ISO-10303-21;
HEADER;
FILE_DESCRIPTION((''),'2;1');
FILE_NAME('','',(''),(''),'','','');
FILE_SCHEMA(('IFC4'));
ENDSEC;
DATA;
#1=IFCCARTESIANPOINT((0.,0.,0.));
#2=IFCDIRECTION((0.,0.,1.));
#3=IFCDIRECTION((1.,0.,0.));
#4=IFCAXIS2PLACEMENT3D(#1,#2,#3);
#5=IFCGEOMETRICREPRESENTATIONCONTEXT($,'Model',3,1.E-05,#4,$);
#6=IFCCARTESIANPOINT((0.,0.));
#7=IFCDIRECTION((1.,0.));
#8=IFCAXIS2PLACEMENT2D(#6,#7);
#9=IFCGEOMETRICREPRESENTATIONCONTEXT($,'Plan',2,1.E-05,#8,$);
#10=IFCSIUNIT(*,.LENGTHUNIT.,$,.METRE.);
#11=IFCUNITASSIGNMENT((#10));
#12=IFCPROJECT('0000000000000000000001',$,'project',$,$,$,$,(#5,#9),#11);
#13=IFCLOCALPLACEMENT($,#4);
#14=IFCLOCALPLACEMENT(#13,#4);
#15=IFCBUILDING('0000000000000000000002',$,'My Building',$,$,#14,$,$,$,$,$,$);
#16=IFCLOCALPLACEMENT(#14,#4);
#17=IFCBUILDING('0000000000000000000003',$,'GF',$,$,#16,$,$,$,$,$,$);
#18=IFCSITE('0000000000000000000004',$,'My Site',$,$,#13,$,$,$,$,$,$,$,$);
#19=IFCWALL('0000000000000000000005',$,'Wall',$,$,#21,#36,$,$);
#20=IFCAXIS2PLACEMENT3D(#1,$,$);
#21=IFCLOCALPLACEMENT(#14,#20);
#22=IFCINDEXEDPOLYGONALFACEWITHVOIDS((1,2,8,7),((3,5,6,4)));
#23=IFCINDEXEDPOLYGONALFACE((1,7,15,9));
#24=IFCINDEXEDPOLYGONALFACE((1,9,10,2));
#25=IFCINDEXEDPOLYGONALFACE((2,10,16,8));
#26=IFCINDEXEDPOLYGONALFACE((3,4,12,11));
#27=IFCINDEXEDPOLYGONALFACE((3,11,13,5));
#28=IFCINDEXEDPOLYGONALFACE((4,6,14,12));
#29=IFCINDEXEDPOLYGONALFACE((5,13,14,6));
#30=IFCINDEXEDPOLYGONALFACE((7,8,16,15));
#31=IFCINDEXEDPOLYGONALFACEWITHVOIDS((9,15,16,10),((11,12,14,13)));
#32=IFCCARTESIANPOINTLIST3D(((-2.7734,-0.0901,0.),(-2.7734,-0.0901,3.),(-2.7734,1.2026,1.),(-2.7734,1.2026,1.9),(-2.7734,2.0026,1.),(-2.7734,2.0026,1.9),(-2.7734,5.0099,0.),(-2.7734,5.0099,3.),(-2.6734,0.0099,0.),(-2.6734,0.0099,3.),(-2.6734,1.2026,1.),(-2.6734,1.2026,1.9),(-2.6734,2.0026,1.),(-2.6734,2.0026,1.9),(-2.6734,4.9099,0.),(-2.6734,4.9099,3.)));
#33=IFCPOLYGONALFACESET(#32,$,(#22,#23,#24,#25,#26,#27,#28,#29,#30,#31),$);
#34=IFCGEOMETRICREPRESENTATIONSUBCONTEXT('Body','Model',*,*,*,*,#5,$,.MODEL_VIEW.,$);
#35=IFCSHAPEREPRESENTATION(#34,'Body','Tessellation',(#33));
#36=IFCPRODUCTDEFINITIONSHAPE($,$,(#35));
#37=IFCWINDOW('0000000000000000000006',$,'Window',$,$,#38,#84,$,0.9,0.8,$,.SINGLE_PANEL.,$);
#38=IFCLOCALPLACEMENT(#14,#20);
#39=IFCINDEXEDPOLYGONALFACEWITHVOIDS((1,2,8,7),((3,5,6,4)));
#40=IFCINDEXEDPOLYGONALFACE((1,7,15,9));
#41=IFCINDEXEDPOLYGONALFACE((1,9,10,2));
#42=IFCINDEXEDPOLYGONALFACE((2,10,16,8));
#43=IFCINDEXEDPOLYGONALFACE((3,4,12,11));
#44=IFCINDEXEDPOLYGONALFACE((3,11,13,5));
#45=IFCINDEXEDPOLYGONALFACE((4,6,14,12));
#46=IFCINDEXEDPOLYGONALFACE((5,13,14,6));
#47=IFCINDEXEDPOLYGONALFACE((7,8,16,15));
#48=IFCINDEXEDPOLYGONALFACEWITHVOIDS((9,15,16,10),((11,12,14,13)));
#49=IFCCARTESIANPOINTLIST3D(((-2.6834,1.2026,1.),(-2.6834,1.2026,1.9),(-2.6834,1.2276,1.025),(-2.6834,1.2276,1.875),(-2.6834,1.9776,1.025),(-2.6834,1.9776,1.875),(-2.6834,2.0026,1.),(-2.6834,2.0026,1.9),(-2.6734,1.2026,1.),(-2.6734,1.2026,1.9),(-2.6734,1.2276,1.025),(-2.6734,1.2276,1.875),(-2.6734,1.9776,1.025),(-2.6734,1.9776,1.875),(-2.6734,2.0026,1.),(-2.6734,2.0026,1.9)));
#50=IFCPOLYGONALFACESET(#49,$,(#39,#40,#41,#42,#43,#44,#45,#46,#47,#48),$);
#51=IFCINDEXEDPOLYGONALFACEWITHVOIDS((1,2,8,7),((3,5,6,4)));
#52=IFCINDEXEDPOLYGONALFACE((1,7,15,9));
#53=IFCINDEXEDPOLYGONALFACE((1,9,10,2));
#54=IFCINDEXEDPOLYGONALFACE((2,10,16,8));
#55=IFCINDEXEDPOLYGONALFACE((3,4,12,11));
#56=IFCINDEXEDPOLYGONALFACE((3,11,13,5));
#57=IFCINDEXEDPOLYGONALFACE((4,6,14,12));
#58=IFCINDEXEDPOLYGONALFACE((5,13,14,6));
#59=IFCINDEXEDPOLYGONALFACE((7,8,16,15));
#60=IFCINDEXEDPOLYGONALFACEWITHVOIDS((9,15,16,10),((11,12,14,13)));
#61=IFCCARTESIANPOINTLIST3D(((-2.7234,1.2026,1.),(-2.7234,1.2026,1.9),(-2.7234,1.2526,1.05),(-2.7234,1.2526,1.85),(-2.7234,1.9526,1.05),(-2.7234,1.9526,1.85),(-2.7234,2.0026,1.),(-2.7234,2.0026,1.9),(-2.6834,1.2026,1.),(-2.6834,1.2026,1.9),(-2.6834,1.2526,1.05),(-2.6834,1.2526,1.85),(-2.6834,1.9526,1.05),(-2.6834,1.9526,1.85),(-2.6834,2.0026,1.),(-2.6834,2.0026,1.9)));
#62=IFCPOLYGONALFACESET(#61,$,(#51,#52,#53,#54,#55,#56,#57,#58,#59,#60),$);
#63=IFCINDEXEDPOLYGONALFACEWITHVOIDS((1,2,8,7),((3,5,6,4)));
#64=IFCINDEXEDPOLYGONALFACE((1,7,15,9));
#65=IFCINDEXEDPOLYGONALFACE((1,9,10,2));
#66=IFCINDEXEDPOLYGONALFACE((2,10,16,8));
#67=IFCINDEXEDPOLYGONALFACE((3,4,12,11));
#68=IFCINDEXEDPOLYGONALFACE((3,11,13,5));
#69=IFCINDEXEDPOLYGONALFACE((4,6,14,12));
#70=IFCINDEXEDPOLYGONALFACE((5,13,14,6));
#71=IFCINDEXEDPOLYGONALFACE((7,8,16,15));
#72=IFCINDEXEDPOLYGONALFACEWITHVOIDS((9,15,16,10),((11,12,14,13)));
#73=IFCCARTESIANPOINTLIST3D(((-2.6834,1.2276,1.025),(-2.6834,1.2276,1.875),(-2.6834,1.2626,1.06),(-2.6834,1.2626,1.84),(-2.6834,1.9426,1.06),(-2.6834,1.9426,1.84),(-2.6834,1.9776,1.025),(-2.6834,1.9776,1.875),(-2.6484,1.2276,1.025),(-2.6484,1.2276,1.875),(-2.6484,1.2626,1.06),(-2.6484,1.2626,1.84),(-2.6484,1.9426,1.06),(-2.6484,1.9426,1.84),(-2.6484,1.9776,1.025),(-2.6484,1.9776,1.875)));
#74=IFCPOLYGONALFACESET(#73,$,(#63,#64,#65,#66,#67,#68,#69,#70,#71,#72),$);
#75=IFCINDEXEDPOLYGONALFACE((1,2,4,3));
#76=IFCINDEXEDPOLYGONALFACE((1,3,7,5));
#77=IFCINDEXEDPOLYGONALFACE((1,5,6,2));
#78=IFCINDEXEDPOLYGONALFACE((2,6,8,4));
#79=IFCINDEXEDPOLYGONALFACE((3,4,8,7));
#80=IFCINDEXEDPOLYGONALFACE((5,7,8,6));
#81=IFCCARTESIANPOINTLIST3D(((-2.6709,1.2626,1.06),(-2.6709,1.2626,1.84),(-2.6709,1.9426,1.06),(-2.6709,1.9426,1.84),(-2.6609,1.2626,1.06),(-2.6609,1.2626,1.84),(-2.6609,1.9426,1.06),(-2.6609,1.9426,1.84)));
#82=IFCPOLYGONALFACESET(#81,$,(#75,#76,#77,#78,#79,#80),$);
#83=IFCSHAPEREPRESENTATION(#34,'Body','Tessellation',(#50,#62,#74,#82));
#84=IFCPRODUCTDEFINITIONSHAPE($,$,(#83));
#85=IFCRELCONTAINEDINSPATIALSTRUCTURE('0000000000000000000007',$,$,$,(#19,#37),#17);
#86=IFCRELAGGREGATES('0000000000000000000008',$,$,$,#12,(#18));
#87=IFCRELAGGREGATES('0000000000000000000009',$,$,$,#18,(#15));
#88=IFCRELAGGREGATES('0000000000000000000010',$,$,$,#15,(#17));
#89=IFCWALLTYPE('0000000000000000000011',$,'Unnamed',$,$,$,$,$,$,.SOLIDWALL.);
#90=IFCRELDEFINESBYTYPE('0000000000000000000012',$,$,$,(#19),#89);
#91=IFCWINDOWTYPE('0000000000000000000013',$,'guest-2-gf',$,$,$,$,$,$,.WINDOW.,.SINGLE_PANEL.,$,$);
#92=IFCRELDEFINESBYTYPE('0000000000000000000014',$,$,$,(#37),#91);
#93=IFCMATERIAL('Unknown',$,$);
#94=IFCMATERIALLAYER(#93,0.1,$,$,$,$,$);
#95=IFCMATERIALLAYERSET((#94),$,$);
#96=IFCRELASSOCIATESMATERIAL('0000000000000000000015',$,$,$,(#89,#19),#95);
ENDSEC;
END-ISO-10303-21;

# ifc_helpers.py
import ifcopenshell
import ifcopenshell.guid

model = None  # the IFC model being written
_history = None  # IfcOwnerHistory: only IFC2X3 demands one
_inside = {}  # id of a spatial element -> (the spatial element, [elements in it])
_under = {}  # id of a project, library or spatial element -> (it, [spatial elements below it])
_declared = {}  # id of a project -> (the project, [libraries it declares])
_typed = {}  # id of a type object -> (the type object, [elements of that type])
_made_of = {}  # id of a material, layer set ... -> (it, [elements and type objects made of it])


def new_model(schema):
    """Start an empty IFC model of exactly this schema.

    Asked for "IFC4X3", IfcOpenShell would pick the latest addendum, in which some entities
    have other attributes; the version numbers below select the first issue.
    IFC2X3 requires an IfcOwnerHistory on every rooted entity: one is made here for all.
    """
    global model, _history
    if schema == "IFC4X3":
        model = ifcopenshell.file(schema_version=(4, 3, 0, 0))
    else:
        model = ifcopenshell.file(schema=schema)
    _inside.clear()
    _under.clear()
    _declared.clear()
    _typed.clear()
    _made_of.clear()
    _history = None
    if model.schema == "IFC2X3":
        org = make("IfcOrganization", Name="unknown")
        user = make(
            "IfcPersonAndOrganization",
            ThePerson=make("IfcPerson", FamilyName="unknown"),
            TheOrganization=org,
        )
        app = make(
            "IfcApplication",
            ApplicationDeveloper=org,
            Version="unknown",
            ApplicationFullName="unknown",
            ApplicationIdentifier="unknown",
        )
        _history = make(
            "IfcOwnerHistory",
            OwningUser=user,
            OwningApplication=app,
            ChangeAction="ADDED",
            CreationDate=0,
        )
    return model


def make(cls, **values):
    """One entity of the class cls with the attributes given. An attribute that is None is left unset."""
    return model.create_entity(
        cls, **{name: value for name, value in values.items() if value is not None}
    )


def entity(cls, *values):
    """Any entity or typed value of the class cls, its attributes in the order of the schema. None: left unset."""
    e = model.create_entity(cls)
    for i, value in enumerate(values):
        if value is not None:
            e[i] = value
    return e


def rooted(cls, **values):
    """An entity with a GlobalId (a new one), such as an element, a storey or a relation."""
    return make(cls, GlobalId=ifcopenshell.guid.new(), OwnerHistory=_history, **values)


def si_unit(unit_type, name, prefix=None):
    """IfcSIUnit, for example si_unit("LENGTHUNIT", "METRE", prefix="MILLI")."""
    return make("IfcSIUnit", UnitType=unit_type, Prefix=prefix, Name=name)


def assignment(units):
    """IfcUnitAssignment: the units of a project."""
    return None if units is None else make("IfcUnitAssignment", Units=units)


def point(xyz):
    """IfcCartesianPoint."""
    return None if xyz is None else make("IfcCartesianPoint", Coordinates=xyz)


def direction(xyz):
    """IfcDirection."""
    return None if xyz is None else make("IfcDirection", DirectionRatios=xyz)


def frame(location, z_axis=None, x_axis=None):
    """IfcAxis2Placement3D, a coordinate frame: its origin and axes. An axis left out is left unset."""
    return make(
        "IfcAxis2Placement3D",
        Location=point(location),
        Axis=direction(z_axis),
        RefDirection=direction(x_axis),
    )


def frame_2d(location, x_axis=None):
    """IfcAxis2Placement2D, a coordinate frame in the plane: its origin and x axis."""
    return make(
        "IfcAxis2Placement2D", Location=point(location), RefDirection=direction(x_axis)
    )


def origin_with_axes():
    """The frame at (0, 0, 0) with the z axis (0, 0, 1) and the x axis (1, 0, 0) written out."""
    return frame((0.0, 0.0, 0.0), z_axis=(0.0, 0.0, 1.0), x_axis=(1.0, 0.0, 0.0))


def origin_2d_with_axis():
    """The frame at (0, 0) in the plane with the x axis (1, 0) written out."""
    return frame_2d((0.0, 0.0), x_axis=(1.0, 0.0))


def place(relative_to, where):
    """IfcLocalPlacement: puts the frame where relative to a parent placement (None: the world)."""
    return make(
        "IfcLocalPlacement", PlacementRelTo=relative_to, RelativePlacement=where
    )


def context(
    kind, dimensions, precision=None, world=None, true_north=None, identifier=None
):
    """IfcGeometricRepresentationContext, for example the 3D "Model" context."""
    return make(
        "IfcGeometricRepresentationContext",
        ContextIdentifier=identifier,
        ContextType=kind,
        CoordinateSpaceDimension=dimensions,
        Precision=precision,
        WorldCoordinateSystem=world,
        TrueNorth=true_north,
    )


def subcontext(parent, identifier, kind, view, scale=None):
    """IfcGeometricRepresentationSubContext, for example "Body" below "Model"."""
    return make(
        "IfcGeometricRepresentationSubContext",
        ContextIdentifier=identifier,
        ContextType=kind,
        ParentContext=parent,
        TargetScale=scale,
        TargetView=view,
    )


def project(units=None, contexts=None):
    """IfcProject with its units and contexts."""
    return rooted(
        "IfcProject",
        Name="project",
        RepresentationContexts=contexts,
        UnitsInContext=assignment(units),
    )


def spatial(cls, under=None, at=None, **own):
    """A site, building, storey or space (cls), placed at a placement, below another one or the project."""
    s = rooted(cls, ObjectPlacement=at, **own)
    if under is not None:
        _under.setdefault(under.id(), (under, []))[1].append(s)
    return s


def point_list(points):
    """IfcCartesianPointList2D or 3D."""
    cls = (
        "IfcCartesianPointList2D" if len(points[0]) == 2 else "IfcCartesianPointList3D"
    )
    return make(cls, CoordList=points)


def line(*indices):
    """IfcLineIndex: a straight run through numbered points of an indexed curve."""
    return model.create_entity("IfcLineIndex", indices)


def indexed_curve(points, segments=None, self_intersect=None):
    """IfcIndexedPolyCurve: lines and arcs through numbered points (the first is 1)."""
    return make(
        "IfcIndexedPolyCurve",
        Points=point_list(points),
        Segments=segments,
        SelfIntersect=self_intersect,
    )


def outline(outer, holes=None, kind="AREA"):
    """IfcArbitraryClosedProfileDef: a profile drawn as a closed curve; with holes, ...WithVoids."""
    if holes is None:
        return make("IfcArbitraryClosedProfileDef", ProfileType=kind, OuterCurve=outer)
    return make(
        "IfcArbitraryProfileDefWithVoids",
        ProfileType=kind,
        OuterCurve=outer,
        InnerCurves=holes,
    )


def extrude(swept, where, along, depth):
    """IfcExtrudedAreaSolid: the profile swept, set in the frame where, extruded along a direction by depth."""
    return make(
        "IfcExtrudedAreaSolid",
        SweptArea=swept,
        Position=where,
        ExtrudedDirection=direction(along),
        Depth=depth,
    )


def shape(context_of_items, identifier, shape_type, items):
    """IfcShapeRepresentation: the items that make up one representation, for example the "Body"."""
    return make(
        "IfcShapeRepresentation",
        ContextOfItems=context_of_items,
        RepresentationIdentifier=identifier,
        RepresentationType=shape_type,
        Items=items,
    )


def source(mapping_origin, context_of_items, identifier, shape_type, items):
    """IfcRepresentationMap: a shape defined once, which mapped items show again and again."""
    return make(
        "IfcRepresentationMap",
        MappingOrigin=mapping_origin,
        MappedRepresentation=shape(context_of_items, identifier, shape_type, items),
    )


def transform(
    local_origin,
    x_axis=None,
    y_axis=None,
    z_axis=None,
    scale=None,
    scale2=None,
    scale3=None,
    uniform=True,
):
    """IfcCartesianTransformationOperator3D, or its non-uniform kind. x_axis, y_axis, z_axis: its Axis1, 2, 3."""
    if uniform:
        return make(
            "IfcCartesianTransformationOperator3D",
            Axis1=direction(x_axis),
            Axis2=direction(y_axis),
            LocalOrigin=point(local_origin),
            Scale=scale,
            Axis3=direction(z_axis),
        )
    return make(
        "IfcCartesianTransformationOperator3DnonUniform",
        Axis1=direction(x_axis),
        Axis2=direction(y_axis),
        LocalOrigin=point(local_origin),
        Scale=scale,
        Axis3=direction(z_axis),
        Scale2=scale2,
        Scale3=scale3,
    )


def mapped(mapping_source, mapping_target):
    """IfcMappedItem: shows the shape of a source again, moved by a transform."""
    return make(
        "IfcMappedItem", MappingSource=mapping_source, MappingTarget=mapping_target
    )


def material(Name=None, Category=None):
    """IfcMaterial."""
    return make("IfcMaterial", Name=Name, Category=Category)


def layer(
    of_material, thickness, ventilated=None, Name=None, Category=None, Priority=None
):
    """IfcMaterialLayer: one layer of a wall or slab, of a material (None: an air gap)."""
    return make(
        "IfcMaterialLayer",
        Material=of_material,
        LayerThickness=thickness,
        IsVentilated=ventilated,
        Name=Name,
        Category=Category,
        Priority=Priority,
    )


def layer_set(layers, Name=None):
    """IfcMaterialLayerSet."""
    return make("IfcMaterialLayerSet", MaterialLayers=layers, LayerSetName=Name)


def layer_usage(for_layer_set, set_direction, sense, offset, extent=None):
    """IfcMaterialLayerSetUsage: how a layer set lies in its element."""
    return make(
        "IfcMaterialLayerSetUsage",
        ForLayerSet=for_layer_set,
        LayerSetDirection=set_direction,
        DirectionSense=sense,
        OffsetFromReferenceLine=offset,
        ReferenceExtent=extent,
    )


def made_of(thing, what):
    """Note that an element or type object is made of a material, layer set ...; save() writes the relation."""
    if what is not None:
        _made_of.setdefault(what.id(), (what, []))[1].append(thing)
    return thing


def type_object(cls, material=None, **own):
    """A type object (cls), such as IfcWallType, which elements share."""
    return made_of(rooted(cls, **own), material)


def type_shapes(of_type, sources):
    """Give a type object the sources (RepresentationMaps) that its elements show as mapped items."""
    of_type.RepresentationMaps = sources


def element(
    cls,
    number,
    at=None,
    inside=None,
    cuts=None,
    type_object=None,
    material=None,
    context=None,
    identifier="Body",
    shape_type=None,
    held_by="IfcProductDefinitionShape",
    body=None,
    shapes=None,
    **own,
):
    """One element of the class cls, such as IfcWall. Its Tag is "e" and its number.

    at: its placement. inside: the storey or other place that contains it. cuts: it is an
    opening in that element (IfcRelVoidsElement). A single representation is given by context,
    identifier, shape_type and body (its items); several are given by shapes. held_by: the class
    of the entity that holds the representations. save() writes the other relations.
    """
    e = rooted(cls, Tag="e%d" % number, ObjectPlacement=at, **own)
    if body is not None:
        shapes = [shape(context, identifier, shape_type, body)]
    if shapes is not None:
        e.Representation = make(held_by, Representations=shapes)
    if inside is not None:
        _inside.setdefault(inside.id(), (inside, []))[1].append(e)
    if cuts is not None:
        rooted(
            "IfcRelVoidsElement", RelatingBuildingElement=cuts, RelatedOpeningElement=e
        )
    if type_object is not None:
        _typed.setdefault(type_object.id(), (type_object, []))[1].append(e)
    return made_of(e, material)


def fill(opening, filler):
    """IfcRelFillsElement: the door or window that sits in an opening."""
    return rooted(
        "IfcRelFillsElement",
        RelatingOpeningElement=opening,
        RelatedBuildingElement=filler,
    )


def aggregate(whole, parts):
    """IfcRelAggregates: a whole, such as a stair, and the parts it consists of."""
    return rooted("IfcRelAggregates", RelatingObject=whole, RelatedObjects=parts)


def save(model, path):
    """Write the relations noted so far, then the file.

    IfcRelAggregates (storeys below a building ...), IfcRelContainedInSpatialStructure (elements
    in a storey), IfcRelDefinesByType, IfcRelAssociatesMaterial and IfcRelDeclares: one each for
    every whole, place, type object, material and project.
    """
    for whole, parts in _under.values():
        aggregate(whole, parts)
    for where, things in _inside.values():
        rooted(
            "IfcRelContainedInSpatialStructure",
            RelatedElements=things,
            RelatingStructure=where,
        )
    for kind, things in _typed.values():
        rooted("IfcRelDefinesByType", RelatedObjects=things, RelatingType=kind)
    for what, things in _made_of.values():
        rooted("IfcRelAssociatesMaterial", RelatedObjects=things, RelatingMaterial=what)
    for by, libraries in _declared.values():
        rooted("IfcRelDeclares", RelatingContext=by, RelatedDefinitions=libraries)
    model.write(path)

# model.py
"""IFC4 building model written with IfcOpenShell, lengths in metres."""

from ifc_helpers import new_model, entity, si_unit, frame, origin_with_axes, origin_2d_with_axis, place, context, subcontext, project, spatial, line, indexed_curve, outline, extrude, shape, source, transform, mapped, material, layer, layer_set, layer_usage, type_object, type_shapes, element, fill, save


model = new_model("IFC4")

# Units and contexts
model_context = context("Model", 3, precision=1e-05, world=origin_with_axes())
plan_context = context("Plan", 2, precision=1e-05, world=origin_2d_with_axis())
body_context_1 = subcontext(model_context, "Body", "Model", "MODEL_VIEW")
body_context_2 = subcontext(plan_context, "Body", "Plan", "PLAN_VIEW")
ifc_project = project(units=[si_unit("LENGTHUNIT", "METRE")], contexts=[model_context, plan_context])

# Site, buildings
site_placement = place(None, origin_with_axes())
site = spatial("IfcSite", under=ifc_project, at=site_placement, Name="My Site")
building_1_placement = place(site_placement, origin_with_axes())
building_1 = spatial("IfcBuilding", under=site, at=building_1_placement, Name="My Building")
building_2_placement = place(building_1_placement, origin_with_axes())
building_2 = spatial("IfcBuilding", under=building_1, at=building_2_placement, Name="GF")

# Shared definitions
ifc_material = material(Name="Unknown")

# Shared definitions
ifc_layer_1 = layer(ifc_material, 0.1)
ifc_layer_set_1 = layer_set([ifc_layer_1])
wall_type = type_object("IfcWallType", Name="Unnamed", PredefinedType="SOLIDWALL", material=ifc_layer_set_1)

# Wall, opening, window
ifc_layer_usage_1 = layer_usage(ifc_layer_set_1, "AXIS2", "POSITIVE", 0.0)
wall_1_placement = place(building_2_placement, frame((-2.7734, 5.0099, 0.0), z_axis=(0.0, 0.0, 1.0), x_axis=(0.0, -1.0, 0.0)))
wall_1 = element("IfcWall", 1, at=wall_1_placement, inside=building_2, type_object=wall_type, material=ifc_layer_usage_1, Name="Wall", context=body_context_1, shape_type="SweptSolid", body=[
    extrude(outline(indexed_curve([(0.0, 0.0), (0.1, 0.1), (5.0, 0.1), (5.1, 0.0)], segments=[line(1, 2, 3, 4, 1)])), origin_with_axes(), (0.0, 0.0, 1.0), 3.0),
])
shared_shape_1 = source(origin_with_axes(), body_context_1, "Body", "SweptSolid", [
    extrude(outline(indexed_curve([(0.0, 0.0), (0.8, 0.0), (0.8, 0.9), (0.0, 0.9)], segments=[line(1, 2, 3, 4, 1)])), frame((0.0, -0.6, 0.0), z_axis=(0.0, -1.0, 0.0), x_axis=(1.0, 0.0, 0.0)), (0.0, 0.0, -1.0), 1.2),
])
opening_1_placement = place(wall_1_placement, frame((3.0073, 0.0, 1.0), z_axis=(0.0, 0.0, 1.0), x_axis=(1.0, 0.0, 0.0)))
opening_1 = element("IfcOpeningElement", 2, at=opening_1_placement, cuts=wall_1, PredefinedType="OPENING", context=body_context_1, shape_type="MappedRepresentation", body=[
    mapped(shared_shape_1, transform((0.0, 0.0, 0.0), x_axis=(1.0, 0.0, 0.0), y_axis=(0.0, 1.0, 0.0), z_axis=(0.0, 0.0, 1.0), scale=1.0)),
])
window_type_1 = type_object("IfcWindowType", Name="guest-2-gf", PartitioningType="SINGLE_PANEL", PredefinedType="WINDOW")
shared_shape_2 = source(origin_with_axes(), body_context_1, "Body", "SweptSolid", [
    extrude(outline(indexed_curve([(0.0, 0.0), (0.8, 0.0), (0.8, 0.9), (0.0, 0.9)], segments=[line(1, 2, 3, 4, 1)]), holes=[indexed_curve([(0.025, 0.025), (0.775, 0.025), (0.775, 0.875), (0.025, 0.875)], segments=[line(1, 2, 3, 4, 1)])]), frame((0.0, 0.09, 0.0), z_axis=(0.0, -1.0, 0.0), x_axis=(1.0, 0.0, 0.0)), (0.0, 0.0, -1.0), 0.01),
    extrude(outline(indexed_curve([(0.0, 0.0), (0.8, 0.0), (0.8, 0.9), (0.0, 0.9)], segments=[line(1, 2, 3, 4, 1)]), holes=[indexed_curve([(0.05, 0.05), (0.75, 0.05), (0.75, 0.85), (0.05, 0.85)], segments=[line(1, 2, 3, 4, 1)])]), frame((0.0, 0.05, 0.0), z_axis=(0.0, -1.0, 0.0), x_axis=(1.0, 0.0, 0.0)), (0.0, 0.0, -1.0), 0.04),
    extrude(outline(indexed_curve([(0.0, 0.0), (0.75, 0.0), (0.75, 0.85), (0.0, 0.85)], segments=[line(1, 2, 3, 4, 1)]), holes=[indexed_curve([(0.035, 0.035), (0.715, 0.035), (0.715, 0.815), (0.035, 0.815)], segments=[line(1, 2, 3, 4, 1)])]), frame((0.025, 0.09, 0.025), z_axis=(0.0, -1.0, 0.0), x_axis=(1.0, 0.0, 0.0)), (0.0, 0.0, -1.0), 0.035),
    extrude(outline(indexed_curve([(0.035, 0.035), (0.715, 0.035), (0.715, 0.815), (0.035, 0.815)], segments=[line(1, 2, 3, 4, 1)])), frame((0.025, 0.1025, 0.025), z_axis=(0.0, -1.0, 0.0), x_axis=(1.0, 0.0, 0.0)), (0.0, 0.0, -1.0), 0.01),
])
shared_shape_3 = source(origin_with_axes(), body_context_2, "Body", "Curve2D", [
    entity("IfcIndexedPolyCurve", entity("IfcCartesianPointList2D", [[0.05, 0.05], [0.75, 0.05]])),
    entity("IfcIndexedPolyCurve", entity("IfcCartesianPointList2D", [[0.0, 0.1], [0.025, 0.1], [0.025, 0.09], [0.05, 0.09], [0.05, 0.05], [0.0, 0.05]]), [entity("IfcLineIndex", [1, 2, 3, 4, 5, 6, 1])]),
    entity("IfcIndexedPolyCurve", entity("IfcCartesianPointList2D", [[0.8, 0.1], [0.775, 0.1], [0.775, 0.09], [0.75, 0.09], [0.75, 0.05], [0.8, 0.05]]), [entity("IfcLineIndex", [1, 2, 3, 4, 5, 6, 1])]),
    entity("IfcIndexedPolyCurve", entity("IfcCartesianPointList2D", [[0.025, 0.09], [0.06, 0.09], [0.06, 0.125], [0.025, 0.125]]), [entity("IfcLineIndex", [1, 2, 3, 4, 1])]),
    entity("IfcIndexedPolyCurve", entity("IfcCartesianPointList2D", [[0.775, 0.09], [0.74, 0.09], [0.74, 0.125], [0.775, 0.125]]), [entity("IfcLineIndex", [1, 2, 3, 4, 1])]),
    entity("IfcIndexedPolyCurve", entity("IfcCartesianPointList2D", [[0.06, 0.09], [0.74, 0.09]])),
    entity("IfcIndexedPolyCurve", entity("IfcCartesianPointList2D", [[0.06, 0.125], [0.74, 0.125]])),
    entity("IfcIndexedPolyCurve", entity("IfcCartesianPointList2D", [[0.06, 0.1075], [0.74, 0.1075]])),
])
type_shapes(window_type_1, [shared_shape_2, shared_shape_3])
window_1_placement = place(opening_1_placement, frame((0.0, 0.0, 0.0), z_axis=(0.0, 0.0, 1.0), x_axis=(1.0, 0.0, 0.0)))
window_1 = element("IfcWindow", 3, at=window_1_placement, inside=building_2, type_object=window_type_1, Name="Window", OverallHeight=0.9, OverallWidth=0.8, PartitioningType="SINGLE_PANEL", shapes=[
    shape(body_context_1, "Body", "MappedRepresentation", [mapped(shared_shape_2, transform((0.0, 0.0, 0.0), x_axis=(1.0, 0.0, 0.0), y_axis=(0.0, 1.0, 0.0), z_axis=(0.0, 0.0, 1.0), scale=1.0))]),
    shape(body_context_2, "Body", "MappedRepresentation", [mapped(shared_shape_3, transform((0.0, 0.0, 0.0), x_axis=(1.0, 0.0, 0.0), y_axis=(0.0, 1.0, 0.0), z_axis=(0.0, 0.0, 1.0), scale=1.0))]),
])
fill(opening_1, window_1)

save(model, "model.ifc")
